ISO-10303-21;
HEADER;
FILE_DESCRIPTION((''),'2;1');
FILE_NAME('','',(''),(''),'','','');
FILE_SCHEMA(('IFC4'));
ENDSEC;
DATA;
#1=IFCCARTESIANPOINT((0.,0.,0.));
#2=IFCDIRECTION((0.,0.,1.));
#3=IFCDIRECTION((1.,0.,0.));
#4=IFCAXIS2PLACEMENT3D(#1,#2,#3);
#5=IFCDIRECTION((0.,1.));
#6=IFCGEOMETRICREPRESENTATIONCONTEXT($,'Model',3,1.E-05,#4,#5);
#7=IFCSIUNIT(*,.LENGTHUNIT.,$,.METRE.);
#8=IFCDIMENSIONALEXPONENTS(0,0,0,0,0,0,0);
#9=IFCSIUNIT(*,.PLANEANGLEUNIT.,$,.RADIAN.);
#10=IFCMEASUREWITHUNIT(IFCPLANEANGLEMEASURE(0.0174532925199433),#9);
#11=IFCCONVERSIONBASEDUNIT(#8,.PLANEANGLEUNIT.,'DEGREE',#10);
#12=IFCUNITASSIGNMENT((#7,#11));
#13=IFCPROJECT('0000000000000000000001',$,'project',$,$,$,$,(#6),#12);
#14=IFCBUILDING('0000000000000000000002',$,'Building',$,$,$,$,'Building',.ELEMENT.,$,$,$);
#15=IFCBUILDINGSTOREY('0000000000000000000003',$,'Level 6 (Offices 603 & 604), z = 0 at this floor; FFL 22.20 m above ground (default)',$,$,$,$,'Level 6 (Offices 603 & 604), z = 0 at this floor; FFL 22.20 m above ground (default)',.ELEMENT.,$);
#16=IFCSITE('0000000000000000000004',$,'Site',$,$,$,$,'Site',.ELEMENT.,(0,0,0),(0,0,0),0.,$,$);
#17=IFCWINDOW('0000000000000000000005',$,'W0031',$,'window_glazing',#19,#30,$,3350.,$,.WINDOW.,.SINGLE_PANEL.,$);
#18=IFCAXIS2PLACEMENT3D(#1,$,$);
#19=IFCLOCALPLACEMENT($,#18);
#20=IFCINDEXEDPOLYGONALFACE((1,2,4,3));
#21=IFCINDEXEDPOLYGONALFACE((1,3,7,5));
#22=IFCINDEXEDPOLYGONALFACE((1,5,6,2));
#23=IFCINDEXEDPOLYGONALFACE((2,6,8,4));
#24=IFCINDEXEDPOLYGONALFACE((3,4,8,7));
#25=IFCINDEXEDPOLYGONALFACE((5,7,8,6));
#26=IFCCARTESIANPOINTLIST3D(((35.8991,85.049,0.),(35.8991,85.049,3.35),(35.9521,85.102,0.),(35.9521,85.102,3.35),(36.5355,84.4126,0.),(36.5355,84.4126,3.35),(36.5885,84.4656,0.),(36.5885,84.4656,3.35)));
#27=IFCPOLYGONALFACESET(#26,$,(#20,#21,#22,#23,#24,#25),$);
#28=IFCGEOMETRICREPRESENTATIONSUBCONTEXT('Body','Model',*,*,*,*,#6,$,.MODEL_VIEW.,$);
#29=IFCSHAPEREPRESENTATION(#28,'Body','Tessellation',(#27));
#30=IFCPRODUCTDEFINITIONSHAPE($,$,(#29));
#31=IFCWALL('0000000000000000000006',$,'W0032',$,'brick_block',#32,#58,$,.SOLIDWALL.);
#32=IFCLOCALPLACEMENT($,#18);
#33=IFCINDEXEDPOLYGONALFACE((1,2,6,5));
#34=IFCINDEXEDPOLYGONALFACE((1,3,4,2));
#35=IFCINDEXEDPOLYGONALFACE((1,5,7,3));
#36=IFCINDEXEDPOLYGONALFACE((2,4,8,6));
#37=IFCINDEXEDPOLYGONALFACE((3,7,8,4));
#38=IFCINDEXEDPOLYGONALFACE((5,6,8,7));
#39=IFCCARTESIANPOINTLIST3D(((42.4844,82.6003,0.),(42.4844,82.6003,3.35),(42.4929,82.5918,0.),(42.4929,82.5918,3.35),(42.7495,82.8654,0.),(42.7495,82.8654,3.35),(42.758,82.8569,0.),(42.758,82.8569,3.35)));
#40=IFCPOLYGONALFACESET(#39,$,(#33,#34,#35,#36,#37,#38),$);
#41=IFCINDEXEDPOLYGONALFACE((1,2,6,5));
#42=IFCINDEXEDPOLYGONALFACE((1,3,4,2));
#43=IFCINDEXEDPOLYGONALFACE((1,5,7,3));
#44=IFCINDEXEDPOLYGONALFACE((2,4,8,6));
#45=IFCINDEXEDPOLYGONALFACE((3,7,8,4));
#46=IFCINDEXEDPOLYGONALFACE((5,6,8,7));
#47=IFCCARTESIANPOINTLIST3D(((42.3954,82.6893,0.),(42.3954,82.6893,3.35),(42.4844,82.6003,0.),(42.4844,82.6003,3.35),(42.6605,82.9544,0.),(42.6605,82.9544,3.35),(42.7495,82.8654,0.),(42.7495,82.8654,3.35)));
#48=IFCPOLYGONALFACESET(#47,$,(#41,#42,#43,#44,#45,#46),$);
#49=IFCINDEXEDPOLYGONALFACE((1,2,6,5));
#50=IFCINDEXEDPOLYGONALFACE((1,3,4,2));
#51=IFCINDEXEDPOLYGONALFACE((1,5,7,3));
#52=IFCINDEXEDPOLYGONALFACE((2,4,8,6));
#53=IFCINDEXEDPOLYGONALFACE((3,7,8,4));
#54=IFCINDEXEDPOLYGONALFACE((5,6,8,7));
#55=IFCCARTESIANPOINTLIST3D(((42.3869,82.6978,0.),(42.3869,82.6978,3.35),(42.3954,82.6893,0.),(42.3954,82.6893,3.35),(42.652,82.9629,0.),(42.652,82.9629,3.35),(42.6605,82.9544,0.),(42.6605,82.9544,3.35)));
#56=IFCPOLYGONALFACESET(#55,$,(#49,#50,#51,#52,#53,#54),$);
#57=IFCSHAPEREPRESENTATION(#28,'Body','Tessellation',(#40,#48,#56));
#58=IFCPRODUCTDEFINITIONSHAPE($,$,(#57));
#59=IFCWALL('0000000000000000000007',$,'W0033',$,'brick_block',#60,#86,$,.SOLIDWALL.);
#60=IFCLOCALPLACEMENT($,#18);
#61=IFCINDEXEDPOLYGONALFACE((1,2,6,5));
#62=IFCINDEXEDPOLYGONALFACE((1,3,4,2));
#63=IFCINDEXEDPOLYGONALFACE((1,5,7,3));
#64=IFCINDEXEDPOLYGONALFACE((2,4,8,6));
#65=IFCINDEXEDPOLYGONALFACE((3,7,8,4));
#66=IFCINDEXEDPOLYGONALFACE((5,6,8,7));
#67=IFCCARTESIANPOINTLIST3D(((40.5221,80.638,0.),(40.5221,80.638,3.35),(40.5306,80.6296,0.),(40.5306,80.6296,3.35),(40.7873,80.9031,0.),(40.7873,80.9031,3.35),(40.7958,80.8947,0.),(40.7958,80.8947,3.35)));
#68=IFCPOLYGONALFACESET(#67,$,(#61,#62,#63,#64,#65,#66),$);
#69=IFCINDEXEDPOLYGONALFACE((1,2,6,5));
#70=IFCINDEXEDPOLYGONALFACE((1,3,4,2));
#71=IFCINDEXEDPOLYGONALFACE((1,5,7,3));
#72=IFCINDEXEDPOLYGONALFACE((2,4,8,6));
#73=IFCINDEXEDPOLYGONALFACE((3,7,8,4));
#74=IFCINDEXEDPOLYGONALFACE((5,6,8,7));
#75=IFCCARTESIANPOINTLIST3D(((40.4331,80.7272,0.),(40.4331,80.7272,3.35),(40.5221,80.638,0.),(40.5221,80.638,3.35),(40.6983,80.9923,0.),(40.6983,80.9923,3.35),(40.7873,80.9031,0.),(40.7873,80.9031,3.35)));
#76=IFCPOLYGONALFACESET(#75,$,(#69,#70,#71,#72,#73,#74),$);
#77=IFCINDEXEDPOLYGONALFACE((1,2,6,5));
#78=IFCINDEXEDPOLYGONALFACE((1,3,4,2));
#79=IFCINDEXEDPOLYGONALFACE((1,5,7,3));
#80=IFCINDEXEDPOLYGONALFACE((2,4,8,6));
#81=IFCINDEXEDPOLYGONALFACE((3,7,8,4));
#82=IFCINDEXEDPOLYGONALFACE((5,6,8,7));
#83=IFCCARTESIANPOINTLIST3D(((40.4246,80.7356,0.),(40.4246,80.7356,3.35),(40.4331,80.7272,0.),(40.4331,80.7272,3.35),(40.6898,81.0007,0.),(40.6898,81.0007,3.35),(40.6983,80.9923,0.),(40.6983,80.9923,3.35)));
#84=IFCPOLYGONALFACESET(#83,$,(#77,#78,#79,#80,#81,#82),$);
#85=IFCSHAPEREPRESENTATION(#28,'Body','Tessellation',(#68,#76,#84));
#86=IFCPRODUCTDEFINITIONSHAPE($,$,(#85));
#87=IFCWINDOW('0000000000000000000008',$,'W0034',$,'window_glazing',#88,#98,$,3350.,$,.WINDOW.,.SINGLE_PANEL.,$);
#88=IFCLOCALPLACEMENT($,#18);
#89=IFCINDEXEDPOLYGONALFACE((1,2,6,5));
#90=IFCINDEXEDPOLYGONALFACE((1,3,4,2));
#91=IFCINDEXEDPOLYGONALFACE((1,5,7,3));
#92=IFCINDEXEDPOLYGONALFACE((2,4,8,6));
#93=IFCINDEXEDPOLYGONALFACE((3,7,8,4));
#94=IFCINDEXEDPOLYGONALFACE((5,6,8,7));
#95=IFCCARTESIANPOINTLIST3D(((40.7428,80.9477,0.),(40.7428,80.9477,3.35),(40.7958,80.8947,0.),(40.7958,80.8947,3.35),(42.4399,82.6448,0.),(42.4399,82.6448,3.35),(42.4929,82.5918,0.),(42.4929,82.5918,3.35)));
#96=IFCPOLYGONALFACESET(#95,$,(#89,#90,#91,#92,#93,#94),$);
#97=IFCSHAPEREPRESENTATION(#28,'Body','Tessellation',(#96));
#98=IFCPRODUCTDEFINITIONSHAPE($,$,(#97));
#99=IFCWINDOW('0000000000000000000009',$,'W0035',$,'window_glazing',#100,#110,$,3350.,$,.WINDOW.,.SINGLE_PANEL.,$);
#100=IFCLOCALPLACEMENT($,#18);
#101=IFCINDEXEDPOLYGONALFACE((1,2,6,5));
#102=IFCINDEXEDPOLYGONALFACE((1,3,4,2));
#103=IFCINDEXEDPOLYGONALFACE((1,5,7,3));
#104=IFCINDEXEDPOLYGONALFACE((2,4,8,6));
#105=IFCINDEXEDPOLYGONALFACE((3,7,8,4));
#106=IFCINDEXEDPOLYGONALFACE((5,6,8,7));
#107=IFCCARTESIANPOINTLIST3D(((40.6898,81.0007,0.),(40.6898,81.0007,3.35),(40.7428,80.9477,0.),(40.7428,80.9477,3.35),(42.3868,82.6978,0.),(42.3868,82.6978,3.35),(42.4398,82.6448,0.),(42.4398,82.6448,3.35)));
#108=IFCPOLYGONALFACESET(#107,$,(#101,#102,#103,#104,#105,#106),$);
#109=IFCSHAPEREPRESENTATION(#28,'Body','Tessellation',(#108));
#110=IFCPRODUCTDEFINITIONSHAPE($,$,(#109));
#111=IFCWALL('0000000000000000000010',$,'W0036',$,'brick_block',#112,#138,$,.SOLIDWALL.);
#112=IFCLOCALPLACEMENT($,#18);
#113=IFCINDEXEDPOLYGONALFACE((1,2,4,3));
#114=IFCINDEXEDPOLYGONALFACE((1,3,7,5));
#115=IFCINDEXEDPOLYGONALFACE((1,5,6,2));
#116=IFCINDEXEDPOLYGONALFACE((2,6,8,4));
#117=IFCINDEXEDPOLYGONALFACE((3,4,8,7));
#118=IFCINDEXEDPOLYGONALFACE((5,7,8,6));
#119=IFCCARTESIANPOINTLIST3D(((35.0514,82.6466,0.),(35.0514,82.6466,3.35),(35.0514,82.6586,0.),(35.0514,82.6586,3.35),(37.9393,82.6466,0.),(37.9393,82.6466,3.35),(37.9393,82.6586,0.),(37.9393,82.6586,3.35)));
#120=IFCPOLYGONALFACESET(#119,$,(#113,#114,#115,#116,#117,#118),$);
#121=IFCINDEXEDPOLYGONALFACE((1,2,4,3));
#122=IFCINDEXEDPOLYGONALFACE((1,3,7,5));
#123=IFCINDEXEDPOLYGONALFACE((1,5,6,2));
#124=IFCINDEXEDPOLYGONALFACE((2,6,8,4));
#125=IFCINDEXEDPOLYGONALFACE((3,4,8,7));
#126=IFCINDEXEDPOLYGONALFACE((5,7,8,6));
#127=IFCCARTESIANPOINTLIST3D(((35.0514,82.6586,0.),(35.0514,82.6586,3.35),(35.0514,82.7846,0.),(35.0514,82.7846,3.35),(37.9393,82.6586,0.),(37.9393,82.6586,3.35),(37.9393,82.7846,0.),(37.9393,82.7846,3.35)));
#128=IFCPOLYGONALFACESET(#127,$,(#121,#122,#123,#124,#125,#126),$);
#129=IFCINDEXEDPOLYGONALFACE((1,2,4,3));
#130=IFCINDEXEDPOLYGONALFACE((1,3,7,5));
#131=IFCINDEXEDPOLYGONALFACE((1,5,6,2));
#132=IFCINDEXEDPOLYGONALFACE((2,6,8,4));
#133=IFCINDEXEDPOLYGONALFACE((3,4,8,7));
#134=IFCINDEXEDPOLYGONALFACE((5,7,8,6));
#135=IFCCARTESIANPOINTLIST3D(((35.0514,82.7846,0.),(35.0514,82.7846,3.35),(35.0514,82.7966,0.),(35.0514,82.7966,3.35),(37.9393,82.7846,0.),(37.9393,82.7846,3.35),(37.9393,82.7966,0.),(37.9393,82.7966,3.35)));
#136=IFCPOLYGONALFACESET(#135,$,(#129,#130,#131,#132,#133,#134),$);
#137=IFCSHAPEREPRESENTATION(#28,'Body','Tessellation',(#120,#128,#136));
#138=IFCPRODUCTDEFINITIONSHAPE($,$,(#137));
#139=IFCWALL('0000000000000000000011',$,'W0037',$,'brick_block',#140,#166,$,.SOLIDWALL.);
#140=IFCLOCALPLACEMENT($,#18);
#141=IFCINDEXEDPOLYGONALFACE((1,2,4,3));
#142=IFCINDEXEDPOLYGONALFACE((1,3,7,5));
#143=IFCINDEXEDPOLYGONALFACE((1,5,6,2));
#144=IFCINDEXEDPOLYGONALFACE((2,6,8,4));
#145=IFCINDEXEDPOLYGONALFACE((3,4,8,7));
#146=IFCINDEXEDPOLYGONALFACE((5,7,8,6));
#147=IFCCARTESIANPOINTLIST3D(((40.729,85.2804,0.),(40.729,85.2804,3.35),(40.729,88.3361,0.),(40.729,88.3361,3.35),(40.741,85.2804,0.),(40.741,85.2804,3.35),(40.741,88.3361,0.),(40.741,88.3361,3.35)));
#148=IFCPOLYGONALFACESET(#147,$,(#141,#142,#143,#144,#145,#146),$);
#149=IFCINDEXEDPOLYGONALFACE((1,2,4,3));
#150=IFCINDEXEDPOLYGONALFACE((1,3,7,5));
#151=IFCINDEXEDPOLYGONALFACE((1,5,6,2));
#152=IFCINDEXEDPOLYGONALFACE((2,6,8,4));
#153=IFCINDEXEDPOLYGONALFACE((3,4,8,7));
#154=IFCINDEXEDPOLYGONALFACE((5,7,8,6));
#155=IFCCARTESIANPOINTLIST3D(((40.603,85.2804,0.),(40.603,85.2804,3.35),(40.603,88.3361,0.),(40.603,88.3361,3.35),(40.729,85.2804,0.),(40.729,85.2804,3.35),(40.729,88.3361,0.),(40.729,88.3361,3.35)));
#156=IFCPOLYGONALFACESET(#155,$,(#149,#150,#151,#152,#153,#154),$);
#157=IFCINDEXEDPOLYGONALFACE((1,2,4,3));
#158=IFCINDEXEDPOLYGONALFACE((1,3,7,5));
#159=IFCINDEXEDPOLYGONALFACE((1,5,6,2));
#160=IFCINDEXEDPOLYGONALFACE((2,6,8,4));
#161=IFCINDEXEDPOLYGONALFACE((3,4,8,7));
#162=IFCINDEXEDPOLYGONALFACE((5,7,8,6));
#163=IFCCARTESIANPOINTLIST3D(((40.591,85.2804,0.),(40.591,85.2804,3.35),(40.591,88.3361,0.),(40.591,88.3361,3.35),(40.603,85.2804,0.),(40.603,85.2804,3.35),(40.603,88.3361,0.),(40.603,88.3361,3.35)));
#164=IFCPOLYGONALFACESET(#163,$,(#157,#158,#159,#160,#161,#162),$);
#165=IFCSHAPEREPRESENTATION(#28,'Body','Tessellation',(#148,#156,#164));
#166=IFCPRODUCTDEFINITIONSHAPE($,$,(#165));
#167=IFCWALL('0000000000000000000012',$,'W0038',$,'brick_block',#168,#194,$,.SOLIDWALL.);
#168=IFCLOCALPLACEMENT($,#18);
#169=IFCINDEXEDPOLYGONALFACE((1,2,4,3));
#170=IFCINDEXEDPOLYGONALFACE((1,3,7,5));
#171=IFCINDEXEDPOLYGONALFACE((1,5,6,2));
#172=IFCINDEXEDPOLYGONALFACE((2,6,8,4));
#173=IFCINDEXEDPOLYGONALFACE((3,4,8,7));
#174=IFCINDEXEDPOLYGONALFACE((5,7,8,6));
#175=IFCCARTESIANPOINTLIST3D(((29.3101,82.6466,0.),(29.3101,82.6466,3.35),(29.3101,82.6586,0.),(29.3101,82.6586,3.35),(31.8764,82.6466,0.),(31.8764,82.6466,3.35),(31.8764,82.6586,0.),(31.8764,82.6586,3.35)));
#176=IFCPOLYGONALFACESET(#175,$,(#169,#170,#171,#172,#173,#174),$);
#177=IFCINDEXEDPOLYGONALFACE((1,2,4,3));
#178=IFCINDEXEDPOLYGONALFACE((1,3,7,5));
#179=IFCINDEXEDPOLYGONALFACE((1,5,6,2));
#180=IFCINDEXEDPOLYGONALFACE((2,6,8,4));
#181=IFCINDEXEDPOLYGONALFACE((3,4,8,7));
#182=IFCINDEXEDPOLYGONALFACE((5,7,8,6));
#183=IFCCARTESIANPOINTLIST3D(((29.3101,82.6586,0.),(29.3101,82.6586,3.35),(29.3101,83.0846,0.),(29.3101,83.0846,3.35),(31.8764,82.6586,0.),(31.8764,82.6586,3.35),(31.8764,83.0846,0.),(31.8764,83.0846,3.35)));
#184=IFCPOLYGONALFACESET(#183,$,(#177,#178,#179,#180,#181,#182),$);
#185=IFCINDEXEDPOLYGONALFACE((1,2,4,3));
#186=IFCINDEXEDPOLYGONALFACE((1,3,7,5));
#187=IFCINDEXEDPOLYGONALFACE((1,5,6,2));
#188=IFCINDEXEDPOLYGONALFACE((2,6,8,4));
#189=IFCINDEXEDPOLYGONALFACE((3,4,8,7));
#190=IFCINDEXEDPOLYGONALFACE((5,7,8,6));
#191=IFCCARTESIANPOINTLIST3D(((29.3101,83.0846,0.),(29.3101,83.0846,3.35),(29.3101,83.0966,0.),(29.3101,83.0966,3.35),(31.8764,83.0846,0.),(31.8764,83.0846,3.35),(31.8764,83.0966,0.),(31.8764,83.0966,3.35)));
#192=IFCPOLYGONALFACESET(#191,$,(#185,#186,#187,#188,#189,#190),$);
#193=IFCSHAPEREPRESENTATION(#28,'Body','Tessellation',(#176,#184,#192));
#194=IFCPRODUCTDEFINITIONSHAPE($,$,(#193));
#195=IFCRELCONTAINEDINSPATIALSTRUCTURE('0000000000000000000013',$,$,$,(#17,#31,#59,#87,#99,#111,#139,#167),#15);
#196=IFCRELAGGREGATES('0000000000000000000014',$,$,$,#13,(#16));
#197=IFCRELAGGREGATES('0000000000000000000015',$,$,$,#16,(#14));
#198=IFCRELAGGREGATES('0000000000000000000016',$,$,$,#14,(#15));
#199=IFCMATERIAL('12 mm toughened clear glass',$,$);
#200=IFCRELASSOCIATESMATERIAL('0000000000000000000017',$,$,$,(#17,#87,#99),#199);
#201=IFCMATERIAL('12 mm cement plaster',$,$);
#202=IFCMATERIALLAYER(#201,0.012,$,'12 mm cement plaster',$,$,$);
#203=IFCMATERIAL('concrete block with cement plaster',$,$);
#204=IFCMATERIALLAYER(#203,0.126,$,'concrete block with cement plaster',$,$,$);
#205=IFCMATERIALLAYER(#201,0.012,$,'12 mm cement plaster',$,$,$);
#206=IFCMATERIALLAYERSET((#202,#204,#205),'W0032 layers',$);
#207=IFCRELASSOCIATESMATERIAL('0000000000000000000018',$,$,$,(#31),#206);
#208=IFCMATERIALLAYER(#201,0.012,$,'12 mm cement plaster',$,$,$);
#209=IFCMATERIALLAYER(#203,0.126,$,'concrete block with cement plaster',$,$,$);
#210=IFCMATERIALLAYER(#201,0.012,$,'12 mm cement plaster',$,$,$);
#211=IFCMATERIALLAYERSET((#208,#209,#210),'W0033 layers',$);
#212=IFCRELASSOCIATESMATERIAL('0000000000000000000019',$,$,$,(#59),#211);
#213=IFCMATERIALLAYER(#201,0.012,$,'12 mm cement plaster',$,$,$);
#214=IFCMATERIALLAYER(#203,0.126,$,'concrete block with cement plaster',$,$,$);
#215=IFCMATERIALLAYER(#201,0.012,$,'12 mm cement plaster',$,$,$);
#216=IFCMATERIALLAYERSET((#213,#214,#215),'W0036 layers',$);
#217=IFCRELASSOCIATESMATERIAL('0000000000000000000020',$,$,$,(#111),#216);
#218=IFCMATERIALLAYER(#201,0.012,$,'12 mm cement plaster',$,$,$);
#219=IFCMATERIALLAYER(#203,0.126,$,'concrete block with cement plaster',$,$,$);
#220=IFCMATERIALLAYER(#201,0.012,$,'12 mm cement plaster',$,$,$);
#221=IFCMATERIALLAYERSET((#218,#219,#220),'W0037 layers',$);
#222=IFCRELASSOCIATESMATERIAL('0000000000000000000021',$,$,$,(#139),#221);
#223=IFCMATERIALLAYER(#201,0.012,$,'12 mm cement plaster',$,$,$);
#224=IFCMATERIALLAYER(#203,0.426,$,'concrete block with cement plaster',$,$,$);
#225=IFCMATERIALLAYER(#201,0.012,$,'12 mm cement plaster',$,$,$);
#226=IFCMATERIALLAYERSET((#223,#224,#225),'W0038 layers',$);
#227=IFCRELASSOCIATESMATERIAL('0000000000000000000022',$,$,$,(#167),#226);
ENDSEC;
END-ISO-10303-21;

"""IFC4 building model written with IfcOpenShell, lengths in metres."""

from ifc_helpers import new_model, entity, si_unit, converted_unit, direction, frame, frame_2d, origin_with_axes, origin_2d_with_axis, place, context, subcontext, project, spatial, rectangle, extrude, material, layer, layer_set, layer_usage, element, save


model = new_model("IFC4")

# Units and contexts
model_context = context("Model", 3, precision=1e-05, world=origin_with_axes(), true_north=direction((0.0, 1.0)))
body_context = subcontext(model_context, "Body", "Model", "MODEL_VIEW")
ifc_project = project(units=[si_unit("LENGTHUNIT", "METRE"), converted_unit("PLANEANGLEUNIT", "DEGREE", entity("IfcPlaneAngleMeasure", 0.0174532925199433), si_unit("PLANEANGLEUNIT", "RADIAN"), dimensions=[0, 0, 0, 0, 0, 0, 0])], contexts=[model_context])

# Site, building, storey
site = spatial("IfcSite", under=ifc_project, Name="Site", LongName="Site", CompositionType="ELEMENT", RefLatitude=(0, 0, 0), RefLongitude=(0, 0, 0), RefElevation=0.0)
building = spatial("IfcBuilding", under=site, Name="Building", LongName="Building", CompositionType="ELEMENT")
storey = spatial("IfcBuildingStorey", under=building, Name="Level 6 (Offices 603 & 604), z = 0 at this floor; FFL 22.20 m above ground (default)", LongName="Level 6 (Offices 603 & 604), z = 0 at this floor; FFL 22.20 m above ground (default)", CompositionType="ELEMENT")

# Shared definitions
ifc_material_1 = material(Name="12 mm cement plaster")
ifc_material_2 = material(Name="concrete block with cement plaster")
placement = place(None, origin_with_axes())

# Shared definitions
ifc_material_3 = material(Name="12 mm toughened clear glass")

# Window
element("IfcWindow", 1, at=placement, inside=storey, material=ifc_material_3, Name="W0031", ObjectType="window_glazing", OverallHeight=3350.0, PartitioningType="SINGLE_PANEL", PredefinedType="WINDOW", context=body_context, shape_type="SweptSolid", body=[
    extrude(rectangle(XDim=0.9, YDim=0.075, at=frame_2d((0.0, 0.0), x_axis=(0.707107, -0.707107))), frame((36.2438, 84.7573, 0.0), z_axis=(0.0, 0.0, 1.0), x_axis=(1.0, 0.0, 0.0)), (0.0, 0.0, 1.0), 3.35),
])

# Walls
ifc_layer_1 = layer(ifc_material_1, 0.012, Name="12 mm cement plaster")
ifc_layer_2 = layer(ifc_material_2, 0.126, Name="concrete block with cement plaster")
ifc_layer_3 = layer(ifc_material_1, 0.012, Name="12 mm cement plaster")
ifc_layer_set_1 = layer_set([ifc_layer_1, ifc_layer_2, ifc_layer_3], Name="W0032 layers")
ifc_layer_usage_1 = layer_usage(ifc_layer_set_1, "AXIS2", "POSITIVE", -0.075)
element("IfcWall", 2, at=placement, inside=storey, material=ifc_layer_usage_1, Name="W0032", ObjectType="brick_block", PredefinedType="SOLIDWALL", context=body_context, shape_type="SweptSolid", body=[
    extrude(rectangle(XDim=0.3749, YDim=0.012, at=frame_2d((0.0, 0.0), x_axis=(0.707107, 0.707107))), frame((42.6212, 82.7286, 0.0), z_axis=(0.0, 0.0, 1.0), x_axis=(1.0, 0.0, 0.0)), (0.0, 0.0, 1.0), 3.35),
    extrude(rectangle(XDim=0.3749, YDim=0.126, at=frame_2d((-0.0488, 0.0488), x_axis=(0.707107, 0.707107))), frame((42.6212, 82.7286, 0.0), z_axis=(0.0, 0.0, 1.0), x_axis=(1.0, 0.0, 0.0)), (0.0, 0.0, 1.0), 3.35),
    extrude(rectangle(XDim=0.3749, YDim=0.012, at=frame_2d((-0.0976, 0.0976), x_axis=(0.707107, 0.707107))), frame((42.6212, 82.7286, 0.0), z_axis=(0.0, 0.0, 1.0), x_axis=(1.0, 0.0, 0.0)), (0.0, 0.0, 1.0), 3.35),
])
ifc_layer_4 = layer(ifc_material_1, 0.012, Name="12 mm cement plaster")
ifc_layer_5 = layer(ifc_material_2, 0.126, Name="concrete block with cement plaster")
ifc_layer_6 = layer(ifc_material_1, 0.012, Name="12 mm cement plaster")
ifc_layer_set_2 = layer_set([ifc_layer_4, ifc_layer_5, ifc_layer_6], Name="W0033 layers")
ifc_layer_usage_2 = layer_usage(ifc_layer_set_2, "AXIS2", "POSITIVE", -0.075)
element("IfcWall", 3, at=placement, inside=storey, material=ifc_layer_usage_2, Name="W0033", ObjectType="brick_block", PredefinedType="SOLIDWALL", context=body_context, shape_type="SweptSolid", body=[
    extrude(rectangle(XDim=0.375, YDim=0.012, at=frame_2d((0.0, 0.0), x_axis=(0.70724, 0.706973))), frame((40.659, 80.7664, 0.0), z_axis=(0.0, 0.0, 1.0), x_axis=(1.0, 0.0, 0.0)), (0.0, 0.0, 1.0), 3.35),
    extrude(rectangle(XDim=0.375, YDim=0.126, at=frame_2d((-0.0488, 0.0488), x_axis=(0.70724, 0.706973))), frame((40.659, 80.7664, 0.0), z_axis=(0.0, 0.0, 1.0), x_axis=(1.0, 0.0, 0.0)), (0.0, 0.0, 1.0), 3.35),
    extrude(rectangle(XDim=0.375, YDim=0.012, at=frame_2d((-0.0976, 0.0976), x_axis=(0.70724, 0.706973))), frame((40.659, 80.7664, 0.0), z_axis=(0.0, 0.0, 1.0), x_axis=(1.0, 0.0, 0.0)), (0.0, 0.0, 1.0), 3.35),
])

# Windows
element("IfcWindow", 4, at=placement, inside=storey, material=ifc_material_3, Name="W0034", ObjectType="window_glazing", OverallHeight=3350.0, PartitioningType="SINGLE_PANEL", PredefinedType="WINDOW", context=body_context, shape_type="SweptSolid", body=[
    extrude(rectangle(XDim=2.4001, YDim=0.075, at=frame_2d((0.0, 0.0), x_axis=(0.707107, 0.707107))), frame((41.6178, 81.7698, 0.0), z_axis=(0.0, 0.0, 1.0), x_axis=(1.0, 0.0, 0.0)), (0.0, 0.0, 1.0), 3.35),
])
element("IfcWindow", 5, at=placement, inside=storey, material=ifc_material_3, Name="W0035", ObjectType="window_glazing", OverallHeight=3350.0, PartitioningType="SINGLE_PANEL", PredefinedType="WINDOW", context=body_context, shape_type="SweptSolid", body=[
    extrude(rectangle(XDim=2.4, YDim=0.075, at=frame_2d((0.0, 0.0), x_axis=(0.707086, 0.707128))), frame((41.5648, 81.8227, 0.0), z_axis=(0.0, 0.0, 1.0), x_axis=(1.0, 0.0, 0.0)), (0.0, 0.0, 1.0), 3.35),
])

# Walls
ifc_layer_7 = layer(ifc_material_1, 0.012, Name="12 mm cement plaster")
ifc_layer_8 = layer(ifc_material_2, 0.126, Name="concrete block with cement plaster")
ifc_layer_9 = layer(ifc_material_1, 0.012, Name="12 mm cement plaster")
ifc_layer_set_3 = layer_set([ifc_layer_7, ifc_layer_8, ifc_layer_9], Name="W0036 layers")
ifc_layer_usage_3 = layer_usage(ifc_layer_set_3, "AXIS2", "POSITIVE", -0.075)
element("IfcWall", 6, at=placement, inside=storey, material=ifc_layer_usage_3, Name="W0036", ObjectType="brick_block", PredefinedType="SOLIDWALL", context=body_context, shape_type="SweptSolid", body=[
    extrude(rectangle(XDim=2.8879, YDim=0.012, at=origin_2d_with_axis()), frame((36.4954, 82.6526, 0.0), z_axis=(0.0, 0.0, 1.0), x_axis=(1.0, 0.0, 0.0)), (0.0, 0.0, 1.0), 3.35),
    extrude(rectangle(XDim=2.8879, YDim=0.126, at=frame_2d((0.0, 0.069), x_axis=(1.0, 0.0))), frame((36.4954, 82.6526, 0.0), z_axis=(0.0, 0.0, 1.0), x_axis=(1.0, 0.0, 0.0)), (0.0, 0.0, 1.0), 3.35),
    extrude(rectangle(XDim=2.8879, YDim=0.012, at=frame_2d((0.0, 0.138), x_axis=(1.0, 0.0))), frame((36.4954, 82.6526, 0.0), z_axis=(0.0, 0.0, 1.0), x_axis=(1.0, 0.0, 0.0)), (0.0, 0.0, 1.0), 3.35),
])
ifc_layer_10 = layer(ifc_material_1, 0.012, Name="12 mm cement plaster")
ifc_layer_11 = layer(ifc_material_2, 0.126, Name="concrete block with cement plaster")
ifc_layer_12 = layer(ifc_material_1, 0.012, Name="12 mm cement plaster")
ifc_layer_set_4 = layer_set([ifc_layer_10, ifc_layer_11, ifc_layer_12], Name="W0037 layers")
ifc_layer_usage_4 = layer_usage(ifc_layer_set_4, "AXIS2", "POSITIVE", -0.075)
element("IfcWall", 7, at=placement, inside=storey, material=ifc_layer_usage_4, Name="W0037", ObjectType="brick_block", PredefinedType="SOLIDWALL", context=body_context, shape_type="SweptSolid", body=[
    extrude(rectangle(XDim=3.0557, YDim=0.012, at=frame_2d((0.0, 0.0), x_axis=(0.0, 1.0))), frame((40.735, 86.8083, 0.0), z_axis=(0.0, 0.0, 1.0), x_axis=(1.0, 0.0, 0.0)), (0.0, 0.0, 1.0), 3.35),
    extrude(rectangle(XDim=3.0557, YDim=0.126, at=frame_2d((-0.069, 0.0), x_axis=(0.0, 1.0))), frame((40.735, 86.8083, 0.0), z_axis=(0.0, 0.0, 1.0), x_axis=(1.0, 0.0, 0.0)), (0.0, 0.0, 1.0), 3.35),
    extrude(rectangle(XDim=3.0557, YDim=0.012, at=frame_2d((-0.138, 0.0), x_axis=(0.0, 1.0))), frame((40.735, 86.8083, 0.0), z_axis=(0.0, 0.0, 1.0), x_axis=(1.0, 0.0, 0.0)), (0.0, 0.0, 1.0), 3.35),
])
ifc_layer_13 = layer(ifc_material_1, 0.012, Name="12 mm cement plaster")
ifc_layer_14 = layer(ifc_material_2, 0.426, Name="concrete block with cement plaster")
ifc_layer_15 = layer(ifc_material_1, 0.012, Name="12 mm cement plaster")
ifc_layer_set_5 = layer_set([ifc_layer_13, ifc_layer_14, ifc_layer_15], Name="W0038 layers")
ifc_layer_usage_5 = layer_usage(ifc_layer_set_5, "AXIS2", "POSITIVE", -0.225)
element("IfcWall", 8, at=placement, inside=storey, material=ifc_layer_usage_5, Name="W0038", ObjectType="brick_block", PredefinedType="SOLIDWALL", context=body_context, shape_type="SweptSolid", body=[
    extrude(rectangle(XDim=2.5663, YDim=0.012, at=frame_2d((0.0, 0.0), x_axis=(1.0, 0.0))), frame((30.5933, 82.6526, 0.0), z_axis=(0.0, 0.0, 1.0), x_axis=(1.0, 0.0, 0.0)), (0.0, 0.0, 1.0), 3.35),
    extrude(rectangle(XDim=2.5663, YDim=0.426, at=frame_2d((0.0, 0.219), x_axis=(1.0, 0.0))), frame((30.5933, 82.6526, 0.0), z_axis=(0.0, 0.0, 1.0), x_axis=(1.0, 0.0, 0.0)), (0.0, 0.0, 1.0), 3.35),
    extrude(rectangle(XDim=2.5663, YDim=0.012, at=frame_2d((0.0, 0.438), x_axis=(1.0, 0.0))), frame((30.5933, 82.6526, 0.0), z_axis=(0.0, 0.0, 1.0), x_axis=(1.0, 0.0, 0.0)), (0.0, 0.0, 1.0), 3.35),
])

save(model, "model.ifc")
